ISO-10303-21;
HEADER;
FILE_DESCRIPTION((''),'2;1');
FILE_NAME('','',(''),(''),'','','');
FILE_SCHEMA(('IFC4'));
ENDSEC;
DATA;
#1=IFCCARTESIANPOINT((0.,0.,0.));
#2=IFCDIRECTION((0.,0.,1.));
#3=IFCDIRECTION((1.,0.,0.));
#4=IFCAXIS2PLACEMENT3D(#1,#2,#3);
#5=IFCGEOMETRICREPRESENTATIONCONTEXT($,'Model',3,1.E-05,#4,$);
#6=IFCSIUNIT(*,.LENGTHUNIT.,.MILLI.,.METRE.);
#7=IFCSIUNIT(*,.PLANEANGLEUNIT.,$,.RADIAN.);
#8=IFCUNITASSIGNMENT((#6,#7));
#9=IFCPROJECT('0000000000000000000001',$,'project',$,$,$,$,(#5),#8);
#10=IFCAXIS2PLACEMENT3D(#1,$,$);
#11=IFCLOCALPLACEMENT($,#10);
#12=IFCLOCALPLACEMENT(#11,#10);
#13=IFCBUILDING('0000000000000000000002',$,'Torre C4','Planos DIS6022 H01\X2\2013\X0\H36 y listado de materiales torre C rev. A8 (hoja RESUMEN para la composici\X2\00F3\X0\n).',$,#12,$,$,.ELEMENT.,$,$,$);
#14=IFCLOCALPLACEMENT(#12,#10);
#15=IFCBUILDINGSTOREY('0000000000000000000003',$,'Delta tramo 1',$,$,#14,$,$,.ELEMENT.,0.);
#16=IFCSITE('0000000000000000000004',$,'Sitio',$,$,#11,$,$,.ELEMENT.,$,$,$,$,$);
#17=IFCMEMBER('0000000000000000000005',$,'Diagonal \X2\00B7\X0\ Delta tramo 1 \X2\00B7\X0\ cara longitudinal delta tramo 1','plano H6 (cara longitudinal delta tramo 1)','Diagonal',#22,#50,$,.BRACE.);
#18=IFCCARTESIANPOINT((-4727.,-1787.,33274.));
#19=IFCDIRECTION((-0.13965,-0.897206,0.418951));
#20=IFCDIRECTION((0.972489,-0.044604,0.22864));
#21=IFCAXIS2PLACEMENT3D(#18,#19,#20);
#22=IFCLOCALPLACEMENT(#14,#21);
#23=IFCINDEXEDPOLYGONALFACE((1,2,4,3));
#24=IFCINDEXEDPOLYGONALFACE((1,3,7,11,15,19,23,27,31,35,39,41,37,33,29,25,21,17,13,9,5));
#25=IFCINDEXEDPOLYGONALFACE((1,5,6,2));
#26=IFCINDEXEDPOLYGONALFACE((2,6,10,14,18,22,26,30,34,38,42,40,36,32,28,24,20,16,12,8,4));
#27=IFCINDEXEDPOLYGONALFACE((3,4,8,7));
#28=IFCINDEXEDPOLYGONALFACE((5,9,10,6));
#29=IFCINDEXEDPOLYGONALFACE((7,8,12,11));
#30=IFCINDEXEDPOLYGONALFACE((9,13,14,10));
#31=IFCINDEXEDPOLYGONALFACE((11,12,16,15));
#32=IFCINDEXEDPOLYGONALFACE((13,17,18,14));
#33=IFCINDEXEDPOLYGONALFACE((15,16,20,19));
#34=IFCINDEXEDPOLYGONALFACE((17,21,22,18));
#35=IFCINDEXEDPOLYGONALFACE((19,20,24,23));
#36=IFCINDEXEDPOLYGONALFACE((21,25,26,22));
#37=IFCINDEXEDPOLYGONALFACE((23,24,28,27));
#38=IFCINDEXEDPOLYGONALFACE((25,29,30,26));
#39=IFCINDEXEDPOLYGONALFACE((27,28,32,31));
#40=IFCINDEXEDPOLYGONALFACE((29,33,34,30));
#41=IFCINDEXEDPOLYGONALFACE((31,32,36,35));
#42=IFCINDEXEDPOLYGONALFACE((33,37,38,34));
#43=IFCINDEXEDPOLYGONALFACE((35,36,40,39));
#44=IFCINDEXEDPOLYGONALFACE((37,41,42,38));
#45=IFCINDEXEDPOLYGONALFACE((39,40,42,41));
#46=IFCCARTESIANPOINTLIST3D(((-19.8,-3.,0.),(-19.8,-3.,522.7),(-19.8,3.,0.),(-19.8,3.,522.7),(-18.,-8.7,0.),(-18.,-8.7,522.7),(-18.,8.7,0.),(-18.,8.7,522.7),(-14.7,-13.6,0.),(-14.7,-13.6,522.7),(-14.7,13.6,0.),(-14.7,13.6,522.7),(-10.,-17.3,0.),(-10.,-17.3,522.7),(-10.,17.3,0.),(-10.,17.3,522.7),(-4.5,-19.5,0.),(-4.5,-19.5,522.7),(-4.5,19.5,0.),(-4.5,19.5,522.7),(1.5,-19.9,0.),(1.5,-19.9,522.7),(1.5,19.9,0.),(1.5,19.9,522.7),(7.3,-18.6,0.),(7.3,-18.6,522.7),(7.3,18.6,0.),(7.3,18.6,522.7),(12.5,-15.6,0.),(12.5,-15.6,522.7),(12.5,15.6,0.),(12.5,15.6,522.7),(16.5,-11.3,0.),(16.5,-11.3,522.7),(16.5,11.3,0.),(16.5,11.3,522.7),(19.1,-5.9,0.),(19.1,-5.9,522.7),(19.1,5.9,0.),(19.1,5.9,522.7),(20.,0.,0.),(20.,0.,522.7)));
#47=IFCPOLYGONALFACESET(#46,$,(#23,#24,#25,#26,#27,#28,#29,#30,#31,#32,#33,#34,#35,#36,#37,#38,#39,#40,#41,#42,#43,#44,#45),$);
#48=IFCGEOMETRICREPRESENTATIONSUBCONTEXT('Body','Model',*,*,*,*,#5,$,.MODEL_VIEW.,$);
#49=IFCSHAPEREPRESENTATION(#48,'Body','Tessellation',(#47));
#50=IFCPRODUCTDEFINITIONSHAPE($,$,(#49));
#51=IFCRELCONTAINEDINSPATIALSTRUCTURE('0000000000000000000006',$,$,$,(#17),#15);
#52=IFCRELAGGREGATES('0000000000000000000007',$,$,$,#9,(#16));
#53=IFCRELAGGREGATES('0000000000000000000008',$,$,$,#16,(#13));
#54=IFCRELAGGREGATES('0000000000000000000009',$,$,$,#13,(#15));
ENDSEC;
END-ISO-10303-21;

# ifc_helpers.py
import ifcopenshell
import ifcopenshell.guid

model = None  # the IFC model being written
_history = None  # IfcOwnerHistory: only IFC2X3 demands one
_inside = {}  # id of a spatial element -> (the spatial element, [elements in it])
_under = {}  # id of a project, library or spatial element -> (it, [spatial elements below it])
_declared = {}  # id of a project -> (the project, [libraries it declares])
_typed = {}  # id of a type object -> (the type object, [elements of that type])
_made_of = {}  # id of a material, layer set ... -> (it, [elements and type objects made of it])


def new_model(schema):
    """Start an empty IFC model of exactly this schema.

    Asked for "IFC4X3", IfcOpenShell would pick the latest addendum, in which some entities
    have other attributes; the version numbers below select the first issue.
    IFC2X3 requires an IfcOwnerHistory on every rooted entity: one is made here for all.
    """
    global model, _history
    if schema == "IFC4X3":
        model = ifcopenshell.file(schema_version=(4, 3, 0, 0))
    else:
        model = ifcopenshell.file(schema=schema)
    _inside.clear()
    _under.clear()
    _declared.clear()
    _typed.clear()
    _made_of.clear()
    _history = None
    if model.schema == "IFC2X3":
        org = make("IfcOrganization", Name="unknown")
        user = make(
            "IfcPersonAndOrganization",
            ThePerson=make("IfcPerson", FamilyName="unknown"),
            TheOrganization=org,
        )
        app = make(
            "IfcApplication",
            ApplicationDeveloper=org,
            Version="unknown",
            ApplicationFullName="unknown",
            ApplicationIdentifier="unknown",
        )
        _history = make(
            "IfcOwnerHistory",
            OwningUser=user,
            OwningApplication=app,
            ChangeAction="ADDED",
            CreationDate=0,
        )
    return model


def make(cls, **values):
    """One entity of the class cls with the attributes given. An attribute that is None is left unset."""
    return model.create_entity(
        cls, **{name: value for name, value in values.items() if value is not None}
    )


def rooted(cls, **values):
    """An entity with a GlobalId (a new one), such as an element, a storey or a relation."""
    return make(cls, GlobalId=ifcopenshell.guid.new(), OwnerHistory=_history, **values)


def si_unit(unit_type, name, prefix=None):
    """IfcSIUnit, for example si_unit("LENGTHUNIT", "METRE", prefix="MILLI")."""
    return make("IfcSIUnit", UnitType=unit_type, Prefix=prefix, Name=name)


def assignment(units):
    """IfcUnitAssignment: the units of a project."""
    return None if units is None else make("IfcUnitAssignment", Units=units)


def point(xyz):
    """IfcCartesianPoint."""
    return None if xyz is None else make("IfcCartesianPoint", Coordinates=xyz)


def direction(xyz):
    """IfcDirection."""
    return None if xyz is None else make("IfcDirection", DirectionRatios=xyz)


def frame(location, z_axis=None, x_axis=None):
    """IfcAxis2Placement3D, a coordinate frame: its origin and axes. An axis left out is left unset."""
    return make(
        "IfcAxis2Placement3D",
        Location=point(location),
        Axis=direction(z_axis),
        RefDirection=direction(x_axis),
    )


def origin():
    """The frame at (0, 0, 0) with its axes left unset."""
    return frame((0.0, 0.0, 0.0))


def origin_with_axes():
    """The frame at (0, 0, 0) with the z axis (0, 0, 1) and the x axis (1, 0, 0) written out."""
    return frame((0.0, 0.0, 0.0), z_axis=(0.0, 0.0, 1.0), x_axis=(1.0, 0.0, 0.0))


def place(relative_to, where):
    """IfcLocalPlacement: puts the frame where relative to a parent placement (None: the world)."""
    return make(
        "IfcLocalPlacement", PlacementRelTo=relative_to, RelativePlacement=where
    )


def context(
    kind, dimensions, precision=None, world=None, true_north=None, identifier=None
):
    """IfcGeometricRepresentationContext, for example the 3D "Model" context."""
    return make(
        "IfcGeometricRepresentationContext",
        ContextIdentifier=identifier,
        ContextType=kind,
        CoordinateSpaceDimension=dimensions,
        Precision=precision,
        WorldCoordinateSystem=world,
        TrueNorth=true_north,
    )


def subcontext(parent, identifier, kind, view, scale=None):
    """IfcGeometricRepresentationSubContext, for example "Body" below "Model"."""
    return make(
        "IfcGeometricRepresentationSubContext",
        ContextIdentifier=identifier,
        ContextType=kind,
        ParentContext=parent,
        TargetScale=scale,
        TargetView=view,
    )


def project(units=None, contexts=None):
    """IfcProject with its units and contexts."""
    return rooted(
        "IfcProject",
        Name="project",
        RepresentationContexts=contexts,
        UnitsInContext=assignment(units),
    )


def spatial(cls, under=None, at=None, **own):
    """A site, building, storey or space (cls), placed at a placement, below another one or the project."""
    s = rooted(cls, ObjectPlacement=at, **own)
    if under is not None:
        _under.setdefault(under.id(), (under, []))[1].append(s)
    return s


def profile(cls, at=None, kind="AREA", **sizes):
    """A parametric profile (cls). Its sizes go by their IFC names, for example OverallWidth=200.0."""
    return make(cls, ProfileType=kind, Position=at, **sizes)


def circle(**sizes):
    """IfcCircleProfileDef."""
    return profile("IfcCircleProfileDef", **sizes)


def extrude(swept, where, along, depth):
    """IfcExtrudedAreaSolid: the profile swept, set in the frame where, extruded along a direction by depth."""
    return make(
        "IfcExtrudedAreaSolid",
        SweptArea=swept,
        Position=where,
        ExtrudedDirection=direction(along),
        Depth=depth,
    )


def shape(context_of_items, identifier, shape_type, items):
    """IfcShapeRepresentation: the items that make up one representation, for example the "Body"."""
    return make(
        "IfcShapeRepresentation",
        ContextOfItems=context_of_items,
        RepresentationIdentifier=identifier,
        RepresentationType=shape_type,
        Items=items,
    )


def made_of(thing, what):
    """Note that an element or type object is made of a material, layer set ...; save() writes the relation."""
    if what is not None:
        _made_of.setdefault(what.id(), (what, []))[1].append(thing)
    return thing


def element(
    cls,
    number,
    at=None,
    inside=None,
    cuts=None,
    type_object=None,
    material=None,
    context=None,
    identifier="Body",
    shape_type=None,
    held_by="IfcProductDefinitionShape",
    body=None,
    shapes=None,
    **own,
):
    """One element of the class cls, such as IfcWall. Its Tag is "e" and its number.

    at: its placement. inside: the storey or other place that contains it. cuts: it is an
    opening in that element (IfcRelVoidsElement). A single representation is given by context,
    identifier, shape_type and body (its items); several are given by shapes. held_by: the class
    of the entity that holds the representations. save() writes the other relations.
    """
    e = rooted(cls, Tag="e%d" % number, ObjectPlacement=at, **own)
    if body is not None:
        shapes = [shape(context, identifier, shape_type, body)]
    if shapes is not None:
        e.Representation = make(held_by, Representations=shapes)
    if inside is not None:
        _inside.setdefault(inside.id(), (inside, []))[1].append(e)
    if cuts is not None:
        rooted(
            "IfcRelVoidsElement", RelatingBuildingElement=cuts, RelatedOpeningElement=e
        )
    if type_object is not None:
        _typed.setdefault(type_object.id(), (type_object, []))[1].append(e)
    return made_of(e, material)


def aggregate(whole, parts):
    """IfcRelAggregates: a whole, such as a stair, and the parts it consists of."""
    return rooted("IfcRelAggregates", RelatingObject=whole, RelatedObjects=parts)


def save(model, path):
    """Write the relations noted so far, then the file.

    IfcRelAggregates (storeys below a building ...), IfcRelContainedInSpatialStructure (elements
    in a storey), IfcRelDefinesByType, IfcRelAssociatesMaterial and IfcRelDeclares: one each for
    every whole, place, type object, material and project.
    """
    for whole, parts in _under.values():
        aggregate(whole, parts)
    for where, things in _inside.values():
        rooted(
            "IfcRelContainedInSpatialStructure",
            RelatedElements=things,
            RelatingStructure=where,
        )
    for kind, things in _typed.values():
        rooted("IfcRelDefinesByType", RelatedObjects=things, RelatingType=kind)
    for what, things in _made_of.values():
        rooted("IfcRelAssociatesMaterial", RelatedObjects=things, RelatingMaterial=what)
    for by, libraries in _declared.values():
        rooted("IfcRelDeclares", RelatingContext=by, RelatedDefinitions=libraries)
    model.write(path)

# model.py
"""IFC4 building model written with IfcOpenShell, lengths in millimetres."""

from ifc_helpers import new_model, si_unit, frame, origin, origin_with_axes, place, context, subcontext, project, spatial, circle, extrude, element, save


model = new_model("IFC4")

# Units and contexts
model_context = context("Model", 3, precision=1e-05, world=origin_with_axes())
body_context = subcontext(model_context, "Body", "Model", "MODEL_VIEW")
ifc_project = project(units=[si_unit("LENGTHUNIT", "METRE", prefix="MILLI"), si_unit("PLANEANGLEUNIT", "RADIAN")], contexts=[model_context])

# Site, building, storey
site_placement = place(None, origin())
site = spatial("IfcSite", under=ifc_project, at=site_placement, Name="Sitio", CompositionType="ELEMENT")
building_placement = place(site_placement, origin())
building = spatial("IfcBuilding", under=site, at=building_placement, Name="Torre C4", Description="Planos DIS6022 H01–H36 y listado de materiales torre C rev. A8 (hoja RESUMEN para la composición).", CompositionType="ELEMENT")
storey_placement = place(building_placement, origin())
storey = spatial("IfcBuildingStorey", under=building, at=storey_placement, Name="Delta tramo 1", CompositionType="ELEMENT", Elevation=0.0)

# Member
member_1_placement = place(storey_placement, frame((-4727.0, -1787.0, 33274.0), z_axis=(-0.13965, -0.897206, 0.418951), x_axis=(0.972489, -0.044604, 0.22864)))
element("IfcMember", 1, at=member_1_placement, inside=storey, Name="Diagonal · Delta tramo 1 · cara longitudinal delta tramo 1", Description="plano H6 (cara longitudinal delta tramo 1)", ObjectType="Diagonal", PredefinedType="BRACE", context=body_context, shape_type="SweptSolid", body=[
    extrude(circle(Radius=20.0), None, (0.0, 0.0, 1.0), 522.7),
])

save(model, "model.ifc")
